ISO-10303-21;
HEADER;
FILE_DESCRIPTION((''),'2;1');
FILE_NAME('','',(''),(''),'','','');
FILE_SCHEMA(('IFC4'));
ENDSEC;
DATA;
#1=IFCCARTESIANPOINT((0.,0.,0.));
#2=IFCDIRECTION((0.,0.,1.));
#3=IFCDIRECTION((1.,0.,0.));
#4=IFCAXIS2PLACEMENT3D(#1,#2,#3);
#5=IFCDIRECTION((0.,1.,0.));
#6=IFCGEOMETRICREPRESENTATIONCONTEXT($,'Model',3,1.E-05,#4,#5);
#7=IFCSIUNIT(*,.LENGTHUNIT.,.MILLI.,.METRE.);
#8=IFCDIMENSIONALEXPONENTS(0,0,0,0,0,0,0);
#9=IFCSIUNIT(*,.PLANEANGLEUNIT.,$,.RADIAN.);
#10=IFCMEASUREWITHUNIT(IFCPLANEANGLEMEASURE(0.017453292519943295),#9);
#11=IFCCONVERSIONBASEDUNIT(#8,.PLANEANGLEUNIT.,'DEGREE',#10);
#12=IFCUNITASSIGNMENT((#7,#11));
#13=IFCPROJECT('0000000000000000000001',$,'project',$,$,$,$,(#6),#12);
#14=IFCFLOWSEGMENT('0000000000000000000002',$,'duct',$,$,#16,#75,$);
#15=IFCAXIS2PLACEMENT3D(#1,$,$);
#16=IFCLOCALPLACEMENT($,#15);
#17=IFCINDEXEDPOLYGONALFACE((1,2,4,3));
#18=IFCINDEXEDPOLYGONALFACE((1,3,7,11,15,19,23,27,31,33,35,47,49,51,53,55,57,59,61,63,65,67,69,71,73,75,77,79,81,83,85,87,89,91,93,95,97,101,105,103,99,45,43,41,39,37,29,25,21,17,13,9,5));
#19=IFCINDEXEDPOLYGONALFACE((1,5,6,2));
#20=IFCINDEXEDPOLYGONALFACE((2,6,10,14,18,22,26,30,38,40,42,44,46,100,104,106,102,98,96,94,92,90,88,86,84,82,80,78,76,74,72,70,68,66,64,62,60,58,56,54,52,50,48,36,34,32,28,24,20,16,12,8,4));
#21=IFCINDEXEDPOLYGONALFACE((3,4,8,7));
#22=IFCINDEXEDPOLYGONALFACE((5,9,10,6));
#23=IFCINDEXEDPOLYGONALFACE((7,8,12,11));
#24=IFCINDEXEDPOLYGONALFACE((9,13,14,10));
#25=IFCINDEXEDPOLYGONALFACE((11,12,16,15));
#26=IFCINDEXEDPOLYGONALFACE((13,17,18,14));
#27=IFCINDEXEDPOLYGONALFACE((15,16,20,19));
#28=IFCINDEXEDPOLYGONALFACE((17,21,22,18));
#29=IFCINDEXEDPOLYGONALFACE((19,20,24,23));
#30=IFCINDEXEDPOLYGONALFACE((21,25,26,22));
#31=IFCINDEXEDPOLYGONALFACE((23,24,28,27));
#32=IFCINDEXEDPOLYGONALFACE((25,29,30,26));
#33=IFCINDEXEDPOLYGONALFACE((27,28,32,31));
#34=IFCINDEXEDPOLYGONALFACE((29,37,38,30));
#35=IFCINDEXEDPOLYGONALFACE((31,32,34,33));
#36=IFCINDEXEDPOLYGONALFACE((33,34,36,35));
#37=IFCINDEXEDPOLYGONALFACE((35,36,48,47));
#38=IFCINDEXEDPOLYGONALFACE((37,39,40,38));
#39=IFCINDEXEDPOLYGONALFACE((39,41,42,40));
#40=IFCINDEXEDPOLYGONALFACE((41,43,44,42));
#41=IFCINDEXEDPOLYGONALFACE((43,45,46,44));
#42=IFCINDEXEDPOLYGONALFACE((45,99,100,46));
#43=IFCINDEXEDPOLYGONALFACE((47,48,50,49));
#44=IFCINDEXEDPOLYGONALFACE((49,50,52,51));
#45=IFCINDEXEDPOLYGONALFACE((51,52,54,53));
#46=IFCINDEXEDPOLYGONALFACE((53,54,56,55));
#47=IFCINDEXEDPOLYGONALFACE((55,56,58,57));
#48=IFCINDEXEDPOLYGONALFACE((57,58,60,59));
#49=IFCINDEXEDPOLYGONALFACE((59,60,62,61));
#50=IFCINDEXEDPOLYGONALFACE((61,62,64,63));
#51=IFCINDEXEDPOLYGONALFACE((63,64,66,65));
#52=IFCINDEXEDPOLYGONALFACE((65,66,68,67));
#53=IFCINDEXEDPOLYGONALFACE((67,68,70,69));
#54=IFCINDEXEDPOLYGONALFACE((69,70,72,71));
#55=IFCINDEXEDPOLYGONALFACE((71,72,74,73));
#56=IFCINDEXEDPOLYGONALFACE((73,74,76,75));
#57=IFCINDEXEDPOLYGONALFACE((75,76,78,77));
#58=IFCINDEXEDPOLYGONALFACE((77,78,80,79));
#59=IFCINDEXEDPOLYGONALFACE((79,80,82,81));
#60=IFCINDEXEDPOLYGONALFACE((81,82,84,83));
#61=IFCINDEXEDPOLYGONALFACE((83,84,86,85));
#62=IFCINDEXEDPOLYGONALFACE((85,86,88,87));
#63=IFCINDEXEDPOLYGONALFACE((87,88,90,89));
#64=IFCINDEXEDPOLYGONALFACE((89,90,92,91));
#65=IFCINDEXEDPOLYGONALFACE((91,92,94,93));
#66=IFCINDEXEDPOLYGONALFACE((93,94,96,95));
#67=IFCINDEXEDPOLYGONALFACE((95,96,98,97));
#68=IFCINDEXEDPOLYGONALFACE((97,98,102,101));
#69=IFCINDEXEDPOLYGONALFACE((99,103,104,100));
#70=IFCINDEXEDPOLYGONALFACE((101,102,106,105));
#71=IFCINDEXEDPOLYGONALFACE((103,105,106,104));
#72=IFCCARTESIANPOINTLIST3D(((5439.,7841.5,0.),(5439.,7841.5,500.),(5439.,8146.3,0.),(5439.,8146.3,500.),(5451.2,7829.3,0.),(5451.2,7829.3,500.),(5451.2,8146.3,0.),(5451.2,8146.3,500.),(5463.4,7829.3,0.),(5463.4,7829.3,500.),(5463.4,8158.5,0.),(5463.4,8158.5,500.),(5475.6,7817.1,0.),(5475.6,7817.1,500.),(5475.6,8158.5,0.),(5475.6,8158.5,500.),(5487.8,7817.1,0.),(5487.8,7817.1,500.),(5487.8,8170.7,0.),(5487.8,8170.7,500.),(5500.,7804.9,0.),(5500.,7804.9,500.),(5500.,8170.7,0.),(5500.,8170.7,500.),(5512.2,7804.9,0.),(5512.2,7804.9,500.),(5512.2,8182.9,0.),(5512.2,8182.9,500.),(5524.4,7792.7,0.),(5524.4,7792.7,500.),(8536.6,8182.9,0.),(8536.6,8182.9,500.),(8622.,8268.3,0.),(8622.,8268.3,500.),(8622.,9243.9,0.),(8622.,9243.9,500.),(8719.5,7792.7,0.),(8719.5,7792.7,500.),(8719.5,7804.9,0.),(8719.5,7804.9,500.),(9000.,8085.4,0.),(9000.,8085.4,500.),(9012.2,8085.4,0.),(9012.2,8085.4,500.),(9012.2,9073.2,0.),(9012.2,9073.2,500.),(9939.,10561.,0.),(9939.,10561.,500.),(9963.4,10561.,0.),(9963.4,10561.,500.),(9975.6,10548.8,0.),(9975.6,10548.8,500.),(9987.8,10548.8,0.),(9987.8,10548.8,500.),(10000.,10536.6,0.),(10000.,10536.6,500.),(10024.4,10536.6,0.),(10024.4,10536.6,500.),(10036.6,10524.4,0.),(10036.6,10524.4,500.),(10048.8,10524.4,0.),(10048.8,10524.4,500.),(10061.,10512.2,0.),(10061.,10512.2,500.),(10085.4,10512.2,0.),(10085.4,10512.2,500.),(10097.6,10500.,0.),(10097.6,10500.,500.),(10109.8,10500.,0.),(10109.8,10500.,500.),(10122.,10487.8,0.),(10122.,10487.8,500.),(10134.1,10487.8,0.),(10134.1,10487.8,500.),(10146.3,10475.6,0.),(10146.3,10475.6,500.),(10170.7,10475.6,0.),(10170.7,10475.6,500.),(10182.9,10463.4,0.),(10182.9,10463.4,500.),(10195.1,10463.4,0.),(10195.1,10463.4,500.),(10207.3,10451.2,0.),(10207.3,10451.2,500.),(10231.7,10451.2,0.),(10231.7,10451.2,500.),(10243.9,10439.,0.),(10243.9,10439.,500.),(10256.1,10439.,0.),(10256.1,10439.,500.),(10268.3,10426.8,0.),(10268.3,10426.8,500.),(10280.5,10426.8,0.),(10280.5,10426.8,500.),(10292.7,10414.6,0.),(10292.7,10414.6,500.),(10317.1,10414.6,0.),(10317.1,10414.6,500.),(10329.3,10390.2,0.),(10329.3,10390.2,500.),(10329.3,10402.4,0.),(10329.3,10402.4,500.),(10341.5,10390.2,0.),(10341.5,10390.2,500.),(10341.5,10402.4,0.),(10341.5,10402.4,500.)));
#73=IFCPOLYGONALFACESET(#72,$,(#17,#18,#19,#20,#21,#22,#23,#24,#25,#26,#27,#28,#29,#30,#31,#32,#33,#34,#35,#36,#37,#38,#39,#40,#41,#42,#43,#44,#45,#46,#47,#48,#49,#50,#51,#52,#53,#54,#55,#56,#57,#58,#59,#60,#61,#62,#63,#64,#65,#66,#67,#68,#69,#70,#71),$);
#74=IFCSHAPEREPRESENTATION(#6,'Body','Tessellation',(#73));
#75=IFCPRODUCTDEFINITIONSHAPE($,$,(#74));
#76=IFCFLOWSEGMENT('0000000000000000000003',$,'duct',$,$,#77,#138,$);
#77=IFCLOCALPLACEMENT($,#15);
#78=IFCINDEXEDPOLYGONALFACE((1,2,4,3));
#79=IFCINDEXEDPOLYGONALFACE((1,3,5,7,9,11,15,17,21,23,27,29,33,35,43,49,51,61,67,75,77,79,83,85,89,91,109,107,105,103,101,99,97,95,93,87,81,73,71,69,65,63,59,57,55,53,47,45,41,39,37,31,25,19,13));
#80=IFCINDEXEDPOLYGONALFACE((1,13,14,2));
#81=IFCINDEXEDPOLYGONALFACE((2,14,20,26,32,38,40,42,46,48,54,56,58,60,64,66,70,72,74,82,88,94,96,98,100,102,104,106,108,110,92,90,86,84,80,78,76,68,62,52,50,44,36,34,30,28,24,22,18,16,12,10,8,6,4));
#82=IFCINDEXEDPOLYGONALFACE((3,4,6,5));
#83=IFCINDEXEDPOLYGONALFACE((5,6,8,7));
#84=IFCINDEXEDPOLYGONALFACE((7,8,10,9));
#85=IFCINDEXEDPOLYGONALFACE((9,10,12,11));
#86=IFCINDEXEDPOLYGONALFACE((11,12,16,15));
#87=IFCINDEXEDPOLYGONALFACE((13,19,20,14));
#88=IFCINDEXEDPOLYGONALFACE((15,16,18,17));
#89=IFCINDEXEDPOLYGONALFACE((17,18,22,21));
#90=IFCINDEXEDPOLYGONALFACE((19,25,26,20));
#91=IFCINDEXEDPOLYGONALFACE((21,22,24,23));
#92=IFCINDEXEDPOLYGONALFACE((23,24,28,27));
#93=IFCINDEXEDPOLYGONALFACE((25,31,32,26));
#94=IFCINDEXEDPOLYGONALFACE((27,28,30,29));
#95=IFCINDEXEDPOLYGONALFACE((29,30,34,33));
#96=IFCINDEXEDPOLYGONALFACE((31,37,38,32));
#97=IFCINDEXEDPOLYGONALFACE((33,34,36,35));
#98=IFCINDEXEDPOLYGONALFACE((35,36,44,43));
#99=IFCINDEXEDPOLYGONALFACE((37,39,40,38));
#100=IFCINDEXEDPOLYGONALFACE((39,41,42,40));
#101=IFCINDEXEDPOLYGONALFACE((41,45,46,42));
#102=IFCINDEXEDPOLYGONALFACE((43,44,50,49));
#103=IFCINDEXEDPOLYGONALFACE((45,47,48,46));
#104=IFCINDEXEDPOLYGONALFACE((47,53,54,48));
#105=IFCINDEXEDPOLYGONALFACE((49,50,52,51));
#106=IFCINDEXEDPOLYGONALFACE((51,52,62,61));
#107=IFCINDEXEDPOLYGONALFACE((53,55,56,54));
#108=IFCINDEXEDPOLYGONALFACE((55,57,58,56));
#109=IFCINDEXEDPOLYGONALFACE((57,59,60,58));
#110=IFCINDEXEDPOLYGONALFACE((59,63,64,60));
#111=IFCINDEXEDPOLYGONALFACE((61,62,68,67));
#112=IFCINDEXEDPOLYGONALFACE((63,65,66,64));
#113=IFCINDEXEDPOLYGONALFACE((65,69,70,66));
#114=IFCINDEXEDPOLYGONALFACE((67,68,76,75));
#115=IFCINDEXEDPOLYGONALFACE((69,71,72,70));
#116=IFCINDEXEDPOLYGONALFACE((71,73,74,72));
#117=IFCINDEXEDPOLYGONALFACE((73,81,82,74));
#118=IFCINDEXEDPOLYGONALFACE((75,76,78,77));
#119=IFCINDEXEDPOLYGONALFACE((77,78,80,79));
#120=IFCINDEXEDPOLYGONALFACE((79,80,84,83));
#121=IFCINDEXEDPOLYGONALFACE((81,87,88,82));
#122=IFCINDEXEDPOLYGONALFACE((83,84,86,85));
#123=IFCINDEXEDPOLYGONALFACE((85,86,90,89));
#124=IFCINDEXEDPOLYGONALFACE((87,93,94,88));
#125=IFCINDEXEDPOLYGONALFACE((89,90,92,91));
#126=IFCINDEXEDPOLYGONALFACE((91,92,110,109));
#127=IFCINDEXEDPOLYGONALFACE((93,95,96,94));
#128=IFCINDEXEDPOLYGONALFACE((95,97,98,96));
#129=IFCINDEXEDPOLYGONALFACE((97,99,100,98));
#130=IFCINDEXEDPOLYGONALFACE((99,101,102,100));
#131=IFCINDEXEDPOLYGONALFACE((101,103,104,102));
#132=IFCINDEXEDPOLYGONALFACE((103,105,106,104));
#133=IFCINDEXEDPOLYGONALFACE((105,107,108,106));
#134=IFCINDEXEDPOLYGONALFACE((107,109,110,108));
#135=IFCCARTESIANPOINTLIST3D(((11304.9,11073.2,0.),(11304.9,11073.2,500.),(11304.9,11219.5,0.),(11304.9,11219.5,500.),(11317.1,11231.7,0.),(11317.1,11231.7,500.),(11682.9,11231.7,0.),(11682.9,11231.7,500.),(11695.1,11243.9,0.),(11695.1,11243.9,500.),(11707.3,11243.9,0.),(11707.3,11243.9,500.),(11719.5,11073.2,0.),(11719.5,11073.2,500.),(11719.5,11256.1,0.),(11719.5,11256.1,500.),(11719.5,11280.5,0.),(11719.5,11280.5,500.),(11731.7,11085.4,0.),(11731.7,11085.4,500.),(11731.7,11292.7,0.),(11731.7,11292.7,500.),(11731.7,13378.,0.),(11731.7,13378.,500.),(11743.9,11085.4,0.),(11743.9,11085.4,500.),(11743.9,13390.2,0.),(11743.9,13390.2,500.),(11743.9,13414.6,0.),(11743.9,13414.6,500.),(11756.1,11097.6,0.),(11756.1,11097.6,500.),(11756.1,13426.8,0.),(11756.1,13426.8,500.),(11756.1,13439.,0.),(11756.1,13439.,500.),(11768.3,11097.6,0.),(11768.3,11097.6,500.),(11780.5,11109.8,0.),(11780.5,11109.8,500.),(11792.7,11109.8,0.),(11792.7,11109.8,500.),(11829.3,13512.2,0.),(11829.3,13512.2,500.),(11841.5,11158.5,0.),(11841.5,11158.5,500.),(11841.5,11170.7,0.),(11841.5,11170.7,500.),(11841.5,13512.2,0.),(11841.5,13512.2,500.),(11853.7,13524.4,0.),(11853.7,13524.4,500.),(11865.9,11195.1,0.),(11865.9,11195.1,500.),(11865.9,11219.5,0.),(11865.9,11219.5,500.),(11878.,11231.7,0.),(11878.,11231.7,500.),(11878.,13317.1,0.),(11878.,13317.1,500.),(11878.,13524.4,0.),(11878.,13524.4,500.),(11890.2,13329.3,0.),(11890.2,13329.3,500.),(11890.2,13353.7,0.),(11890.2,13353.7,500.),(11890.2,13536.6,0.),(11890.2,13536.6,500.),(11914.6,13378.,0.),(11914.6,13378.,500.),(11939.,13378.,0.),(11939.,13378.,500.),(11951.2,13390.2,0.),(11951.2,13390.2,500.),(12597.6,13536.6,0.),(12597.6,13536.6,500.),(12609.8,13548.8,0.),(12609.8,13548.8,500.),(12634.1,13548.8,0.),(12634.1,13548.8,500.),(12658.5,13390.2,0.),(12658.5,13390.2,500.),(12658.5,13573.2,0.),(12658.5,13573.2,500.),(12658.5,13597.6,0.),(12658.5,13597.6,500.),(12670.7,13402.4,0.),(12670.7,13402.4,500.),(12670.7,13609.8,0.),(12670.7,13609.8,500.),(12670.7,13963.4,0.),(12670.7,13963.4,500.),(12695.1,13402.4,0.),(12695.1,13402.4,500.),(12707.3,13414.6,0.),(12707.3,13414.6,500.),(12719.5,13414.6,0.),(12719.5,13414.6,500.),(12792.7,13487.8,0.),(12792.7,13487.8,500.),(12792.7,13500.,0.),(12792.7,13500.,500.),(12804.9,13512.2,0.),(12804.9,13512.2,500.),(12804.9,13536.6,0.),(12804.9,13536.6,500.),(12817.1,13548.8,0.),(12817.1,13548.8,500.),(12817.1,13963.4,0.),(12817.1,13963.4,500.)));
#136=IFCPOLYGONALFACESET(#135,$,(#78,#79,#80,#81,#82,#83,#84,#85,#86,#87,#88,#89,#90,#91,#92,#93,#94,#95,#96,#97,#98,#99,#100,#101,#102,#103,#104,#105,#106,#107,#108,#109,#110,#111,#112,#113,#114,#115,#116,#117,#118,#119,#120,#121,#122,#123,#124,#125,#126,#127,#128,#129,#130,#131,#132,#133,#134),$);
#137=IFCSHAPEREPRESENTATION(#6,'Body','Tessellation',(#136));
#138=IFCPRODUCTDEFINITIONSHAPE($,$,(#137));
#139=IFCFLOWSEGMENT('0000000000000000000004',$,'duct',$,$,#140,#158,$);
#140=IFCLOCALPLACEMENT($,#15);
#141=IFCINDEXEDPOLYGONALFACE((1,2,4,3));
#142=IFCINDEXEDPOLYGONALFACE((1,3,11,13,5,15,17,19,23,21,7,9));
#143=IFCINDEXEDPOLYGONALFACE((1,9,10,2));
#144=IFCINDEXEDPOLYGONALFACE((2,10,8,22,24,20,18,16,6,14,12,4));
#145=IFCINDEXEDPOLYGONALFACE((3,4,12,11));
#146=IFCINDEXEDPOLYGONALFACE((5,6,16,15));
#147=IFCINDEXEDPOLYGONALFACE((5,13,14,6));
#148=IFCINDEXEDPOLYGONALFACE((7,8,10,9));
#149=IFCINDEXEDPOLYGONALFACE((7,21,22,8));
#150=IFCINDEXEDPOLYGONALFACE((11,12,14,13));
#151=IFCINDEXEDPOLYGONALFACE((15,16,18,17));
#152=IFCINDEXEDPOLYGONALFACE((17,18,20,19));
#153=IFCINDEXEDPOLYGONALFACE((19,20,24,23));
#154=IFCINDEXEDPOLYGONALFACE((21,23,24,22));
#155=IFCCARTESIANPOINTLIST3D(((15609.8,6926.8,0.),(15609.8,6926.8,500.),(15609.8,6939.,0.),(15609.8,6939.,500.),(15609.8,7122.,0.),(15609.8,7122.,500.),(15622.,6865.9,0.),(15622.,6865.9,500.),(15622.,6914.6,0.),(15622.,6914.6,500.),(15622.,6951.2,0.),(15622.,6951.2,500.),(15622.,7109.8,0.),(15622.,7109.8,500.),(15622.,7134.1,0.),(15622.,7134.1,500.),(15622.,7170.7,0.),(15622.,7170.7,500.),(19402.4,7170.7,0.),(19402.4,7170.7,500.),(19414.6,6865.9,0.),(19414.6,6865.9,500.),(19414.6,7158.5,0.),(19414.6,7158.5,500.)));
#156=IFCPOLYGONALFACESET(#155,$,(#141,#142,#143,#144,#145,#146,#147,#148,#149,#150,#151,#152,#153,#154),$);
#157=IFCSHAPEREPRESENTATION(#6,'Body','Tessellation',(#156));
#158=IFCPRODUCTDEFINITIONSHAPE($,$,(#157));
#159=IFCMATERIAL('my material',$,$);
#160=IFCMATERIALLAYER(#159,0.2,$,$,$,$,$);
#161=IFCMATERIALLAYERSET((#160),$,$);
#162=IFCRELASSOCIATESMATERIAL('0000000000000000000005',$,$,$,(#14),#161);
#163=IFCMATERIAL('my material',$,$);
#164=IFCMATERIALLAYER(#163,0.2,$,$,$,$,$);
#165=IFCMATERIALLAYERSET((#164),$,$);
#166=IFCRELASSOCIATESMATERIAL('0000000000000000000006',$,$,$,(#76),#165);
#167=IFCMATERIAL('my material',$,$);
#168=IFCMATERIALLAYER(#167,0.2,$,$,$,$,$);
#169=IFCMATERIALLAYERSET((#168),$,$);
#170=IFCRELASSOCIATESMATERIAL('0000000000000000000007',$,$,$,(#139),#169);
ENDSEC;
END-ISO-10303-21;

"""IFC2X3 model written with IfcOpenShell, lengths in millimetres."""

from ifc_helpers import new_model, entity, si_unit, converted_unit, direction, origin_with_axes, place, context, project, polyline, outline, extrude, material, layer, layer_set, layer_usage, element, save


model = new_model("IFC2X3")

# Units and contexts
model_context = context("Model", 3, precision=1e-05, world=origin_with_axes(), true_north=direction((0.0, 1.0, 0.0)))
ifc_project = project(units=[si_unit("LENGTHUNIT", "METRE", prefix="MILLI"), converted_unit("PLANEANGLEUNIT", "DEGREE", entity("IfcPlaneAngleMeasure", 0.017453292519943295), si_unit("PLANEANGLEUNIT", "RADIAN"), dimensions=[0, 0, 0, 0, 0, 0, 0])], contexts=[model_context])

# Flow segments
ifc_material_1 = material(Name="my material")
ifc_layer_1 = layer(ifc_material_1, 0.2)
ifc_layer_set_1 = layer_set([ifc_layer_1])
ifc_layer_usage_1 = layer_usage(ifc_layer_set_1, "AXIS2", "POSITIVE", -0.1)
flow_segment_1_placement = place(None, origin_with_axes())
element("IfcFlowSegment", 1, at=flow_segment_1_placement, material=ifc_layer_usage_1, Name="duct", context=model_context, shape_type="SweptSolid", body=[
    extrude(outline(polyline([(5439.0, 7841.5), (5451.2, 7829.3), (5463.4, 7829.3), (5475.6, 7817.1), (5487.8, 7817.1), (5500.0, 7804.9), (5512.2, 7804.9), (5524.4, 7792.7), (8719.5, 7792.7), (8719.5, 7804.9), (9000.0, 8085.4), (9012.2, 8085.4), (9012.2, 9073.2), (10329.3, 10390.2), (10341.5, 10390.2), (10341.5, 10402.4), (10329.3, 10402.4), (10317.1, 10414.6), (10292.7, 10414.6), (10280.5, 10426.8), (10268.3, 10426.8), (10256.1, 10439.0), (10243.9, 10439.0), (10231.7, 10451.2), (10207.3, 10451.2), (10195.1, 10463.4), (10182.9, 10463.4), (10170.7, 10475.6), (10146.3, 10475.6), (10134.1, 10487.8), (10122.0, 10487.8), (10109.8, 10500.0), (10097.6, 10500.0), (10085.4, 10512.2), (10061.0, 10512.2), (10048.8, 10524.4), (10036.6, 10524.4), (10024.4, 10536.6), (10000.0, 10536.6), (9987.8, 10548.8), (9975.6, 10548.8), (9963.4, 10561.0), (9939.0, 10561.0), (8622.0, 9243.9), (8622.0, 8268.3), (8536.6, 8182.9), (5512.2, 8182.9), (5500.0, 8170.7), (5487.8, 8170.7), (5475.6, 8158.5), (5463.4, 8158.5), (5451.2, 8146.3), (5439.0, 8146.3), (5439.0, 7841.5)])), origin_with_axes(), (0.0, 0.0, 1.0), 500.0),
])
ifc_material_2 = material(Name="my material")
ifc_layer_2 = layer(ifc_material_2, 0.2)
ifc_layer_set_2 = layer_set([ifc_layer_2])
ifc_layer_usage_2 = layer_usage(ifc_layer_set_2, "AXIS2", "POSITIVE", -0.1)
flow_segment_2_placement = place(None, origin_with_axes())
element("IfcFlowSegment", 2, at=flow_segment_2_placement, material=ifc_layer_usage_2, Name="duct", context=model_context, shape_type="SweptSolid", body=[
    extrude(outline(polyline([(11304.9, 11073.2), (11719.5, 11073.2), (11731.7, 11085.4), (11743.9, 11085.4), (11756.1, 11097.6), (11768.3, 11097.6), (11780.5, 11109.8), (11792.7, 11109.8), (11841.5, 11158.5), (11841.5, 11170.7), (11865.9, 11195.1), (11865.9, 11219.5), (11878.0, 11231.7), (11878.0, 13317.1), (11890.2, 13329.3), (11890.2, 13353.7), (11914.6, 13378.0), (11939.0, 13378.0), (11951.2, 13390.2), (12658.5, 13390.2), (12670.7, 13402.4), (12695.1, 13402.4), (12707.3, 13414.6), (12719.5, 13414.6), (12792.7, 13487.8), (12792.7, 13500.0), (12804.9, 13512.2), (12804.9, 13536.6), (12817.1, 13548.8), (12817.1, 13963.4), (12670.7, 13963.4), (12670.7, 13609.8), (12658.5, 13597.6), (12658.5, 13573.2), (12634.1, 13548.8), (12609.8, 13548.8), (12597.6, 13536.6), (11890.2, 13536.6), (11878.0, 13524.4), (11853.7, 13524.4), (11841.5, 13512.2), (11829.3, 13512.2), (11756.1, 13439.0), (11756.1, 13426.8), (11743.9, 13414.6), (11743.9, 13390.2), (11731.7, 13378.0), (11731.7, 11292.7), (11719.5, 11280.5), (11719.5, 11256.1), (11707.3, 11243.9), (11695.1, 11243.9), (11682.9, 11231.7), (11317.1, 11231.7), (11304.9, 11219.5), (11304.9, 11073.2)])), origin_with_axes(), (0.0, 0.0, 1.0), 500.0),
])
ifc_material_3 = material(Name="my material")
ifc_layer_3 = layer(ifc_material_3, 0.2)
ifc_layer_set_3 = layer_set([ifc_layer_3])
ifc_layer_usage_3 = layer_usage(ifc_layer_set_3, "AXIS2", "POSITIVE", -0.1)
flow_segment_3_placement = place(None, origin_with_axes())
element("IfcFlowSegment", 3, at=flow_segment_3_placement, material=ifc_layer_usage_3, Name="duct", context=model_context, shape_type="SweptSolid", body=[
    extrude(outline(polyline([(15609.8, 6926.8), (15622.0, 6914.6), (15622.0, 6865.9), (19414.6, 6865.9), (19414.6, 7158.5), (19402.4, 7170.7), (15622.0, 7170.7), (15622.0, 7134.1), (15609.8, 7122.0), (15622.0, 7109.8), (15622.0, 6951.2), (15609.8, 6939.0), (15609.8, 6926.8)])), origin_with_axes(), (0.0, 0.0, 1.0), 500.0),
])

save(model, "model.ifc")
